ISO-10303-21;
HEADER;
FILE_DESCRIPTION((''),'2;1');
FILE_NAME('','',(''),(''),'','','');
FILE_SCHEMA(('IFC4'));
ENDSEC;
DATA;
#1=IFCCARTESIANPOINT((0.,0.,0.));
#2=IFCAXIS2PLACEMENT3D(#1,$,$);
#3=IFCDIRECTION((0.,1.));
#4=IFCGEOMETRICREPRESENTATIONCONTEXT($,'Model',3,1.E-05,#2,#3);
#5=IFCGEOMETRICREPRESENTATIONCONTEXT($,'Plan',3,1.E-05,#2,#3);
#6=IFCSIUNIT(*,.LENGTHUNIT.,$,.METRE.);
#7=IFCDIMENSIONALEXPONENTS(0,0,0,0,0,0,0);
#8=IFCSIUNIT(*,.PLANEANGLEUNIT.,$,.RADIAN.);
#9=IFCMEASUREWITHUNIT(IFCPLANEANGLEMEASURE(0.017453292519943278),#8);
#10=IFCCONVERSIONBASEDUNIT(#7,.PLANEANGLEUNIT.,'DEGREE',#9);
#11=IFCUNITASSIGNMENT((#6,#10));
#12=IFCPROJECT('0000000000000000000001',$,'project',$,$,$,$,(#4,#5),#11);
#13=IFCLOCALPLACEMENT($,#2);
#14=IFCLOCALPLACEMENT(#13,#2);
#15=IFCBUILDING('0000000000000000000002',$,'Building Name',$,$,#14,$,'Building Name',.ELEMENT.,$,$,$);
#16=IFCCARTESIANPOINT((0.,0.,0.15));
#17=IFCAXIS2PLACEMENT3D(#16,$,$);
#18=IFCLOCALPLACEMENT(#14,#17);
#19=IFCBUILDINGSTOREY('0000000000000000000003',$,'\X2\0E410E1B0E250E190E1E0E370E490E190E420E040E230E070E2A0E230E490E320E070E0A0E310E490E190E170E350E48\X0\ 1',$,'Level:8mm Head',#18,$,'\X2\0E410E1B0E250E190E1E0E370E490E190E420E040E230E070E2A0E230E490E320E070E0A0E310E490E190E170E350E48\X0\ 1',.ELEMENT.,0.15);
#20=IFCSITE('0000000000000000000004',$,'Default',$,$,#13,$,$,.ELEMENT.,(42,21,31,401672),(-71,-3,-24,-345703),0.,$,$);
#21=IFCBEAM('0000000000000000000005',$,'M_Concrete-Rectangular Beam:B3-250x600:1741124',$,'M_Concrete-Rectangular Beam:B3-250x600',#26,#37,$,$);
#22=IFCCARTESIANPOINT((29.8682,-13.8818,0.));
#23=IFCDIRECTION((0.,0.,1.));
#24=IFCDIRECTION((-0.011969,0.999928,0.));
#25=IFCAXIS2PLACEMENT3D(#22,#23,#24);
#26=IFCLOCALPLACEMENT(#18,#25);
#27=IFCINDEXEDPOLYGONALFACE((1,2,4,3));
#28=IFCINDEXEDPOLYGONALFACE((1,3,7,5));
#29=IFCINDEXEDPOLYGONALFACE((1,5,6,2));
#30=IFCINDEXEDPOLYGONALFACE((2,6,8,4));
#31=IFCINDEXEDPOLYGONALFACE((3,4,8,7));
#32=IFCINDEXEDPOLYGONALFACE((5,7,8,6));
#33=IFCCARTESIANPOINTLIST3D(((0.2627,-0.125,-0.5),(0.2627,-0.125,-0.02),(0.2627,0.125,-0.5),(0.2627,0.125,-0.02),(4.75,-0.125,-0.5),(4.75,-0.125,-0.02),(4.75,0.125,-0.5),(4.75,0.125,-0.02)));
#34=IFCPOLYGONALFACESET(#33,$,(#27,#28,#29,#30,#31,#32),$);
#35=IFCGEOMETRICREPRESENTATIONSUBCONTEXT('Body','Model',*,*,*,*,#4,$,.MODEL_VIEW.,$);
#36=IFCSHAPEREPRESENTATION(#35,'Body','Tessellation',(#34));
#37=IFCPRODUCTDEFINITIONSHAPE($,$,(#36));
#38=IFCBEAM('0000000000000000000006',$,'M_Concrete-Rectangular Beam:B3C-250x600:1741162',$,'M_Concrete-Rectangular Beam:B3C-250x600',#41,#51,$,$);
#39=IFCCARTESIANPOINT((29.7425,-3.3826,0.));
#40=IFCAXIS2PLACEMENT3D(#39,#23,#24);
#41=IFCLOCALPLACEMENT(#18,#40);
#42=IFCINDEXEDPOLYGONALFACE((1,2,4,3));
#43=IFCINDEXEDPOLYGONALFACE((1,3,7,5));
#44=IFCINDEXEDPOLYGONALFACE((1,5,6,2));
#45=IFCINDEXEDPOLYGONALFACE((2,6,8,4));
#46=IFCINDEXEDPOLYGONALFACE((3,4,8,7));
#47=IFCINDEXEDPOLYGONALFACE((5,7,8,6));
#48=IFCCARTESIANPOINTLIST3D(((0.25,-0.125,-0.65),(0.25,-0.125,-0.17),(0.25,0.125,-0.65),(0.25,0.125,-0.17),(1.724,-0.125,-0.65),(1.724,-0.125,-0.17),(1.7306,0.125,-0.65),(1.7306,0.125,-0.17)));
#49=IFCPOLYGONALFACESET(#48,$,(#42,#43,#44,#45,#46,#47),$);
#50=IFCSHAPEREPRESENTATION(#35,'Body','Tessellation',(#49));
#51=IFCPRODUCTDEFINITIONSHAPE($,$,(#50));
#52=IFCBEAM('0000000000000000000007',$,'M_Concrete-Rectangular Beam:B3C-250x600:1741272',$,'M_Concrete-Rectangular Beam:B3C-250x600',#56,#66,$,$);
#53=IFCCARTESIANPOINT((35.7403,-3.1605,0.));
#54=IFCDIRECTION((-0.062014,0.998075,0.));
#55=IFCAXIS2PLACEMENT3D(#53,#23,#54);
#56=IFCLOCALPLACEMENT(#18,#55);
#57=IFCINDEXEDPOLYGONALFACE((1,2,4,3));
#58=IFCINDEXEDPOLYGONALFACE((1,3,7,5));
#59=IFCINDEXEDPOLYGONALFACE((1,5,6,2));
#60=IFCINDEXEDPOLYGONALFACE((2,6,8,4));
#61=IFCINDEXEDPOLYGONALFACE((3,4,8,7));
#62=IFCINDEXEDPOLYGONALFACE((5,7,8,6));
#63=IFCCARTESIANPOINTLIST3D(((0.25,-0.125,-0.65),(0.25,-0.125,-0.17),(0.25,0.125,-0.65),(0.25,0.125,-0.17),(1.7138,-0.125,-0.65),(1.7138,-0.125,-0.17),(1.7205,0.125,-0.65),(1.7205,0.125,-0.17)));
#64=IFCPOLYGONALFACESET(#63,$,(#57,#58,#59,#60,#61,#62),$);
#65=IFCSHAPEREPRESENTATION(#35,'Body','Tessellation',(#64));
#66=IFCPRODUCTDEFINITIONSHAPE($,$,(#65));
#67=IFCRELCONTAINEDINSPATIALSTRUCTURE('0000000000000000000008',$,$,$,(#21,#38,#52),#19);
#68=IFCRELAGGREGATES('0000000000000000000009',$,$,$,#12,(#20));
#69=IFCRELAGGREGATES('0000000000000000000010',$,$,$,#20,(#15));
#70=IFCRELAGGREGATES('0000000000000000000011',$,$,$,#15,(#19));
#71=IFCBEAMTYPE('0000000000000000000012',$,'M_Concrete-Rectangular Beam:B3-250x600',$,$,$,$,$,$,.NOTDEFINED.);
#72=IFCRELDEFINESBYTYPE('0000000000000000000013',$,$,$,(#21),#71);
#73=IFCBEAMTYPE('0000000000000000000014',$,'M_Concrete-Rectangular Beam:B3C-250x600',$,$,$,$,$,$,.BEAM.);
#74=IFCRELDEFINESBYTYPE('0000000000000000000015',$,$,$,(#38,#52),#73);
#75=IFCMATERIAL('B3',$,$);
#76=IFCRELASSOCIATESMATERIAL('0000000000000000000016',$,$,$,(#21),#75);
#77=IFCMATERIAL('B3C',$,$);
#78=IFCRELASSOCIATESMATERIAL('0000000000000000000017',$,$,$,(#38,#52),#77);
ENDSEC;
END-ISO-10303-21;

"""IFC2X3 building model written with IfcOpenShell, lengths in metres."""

from ifc_helpers import new_model, entity, si_unit, converted_unit, direction, frame, frame_2d, origin, place, context, subcontext, project, spatial, rectangle, extrude, clip, halfspace, material, type_object, element, save


model = new_model("IFC2X3")

# Units and contexts
model_context = context("Model", 3, precision=1e-05, world=origin(), true_north=direction((0.0, 1.0)))
plan_context = context("Plan", 3, precision=1e-05, world=origin(), true_north=direction((0.0, 1.0)))
body_context = subcontext(model_context, "Body", "Model", "MODEL_VIEW")
ifc_project = project(units=[si_unit("LENGTHUNIT", "METRE"), converted_unit("PLANEANGLEUNIT", "DEGREE", entity("IfcPlaneAngleMeasure", 0.017453292519943278), si_unit("PLANEANGLEUNIT", "RADIAN"), dimensions=[0, 0, 0, 0, 0, 0, 0])], contexts=[model_context, plan_context])

# Site, building, storey
site_placement = place(None, origin())
site = spatial("IfcSite", under=ifc_project, at=site_placement, Name="Default", CompositionType="ELEMENT", RefLatitude=(42, 21, 31, 401672), RefLongitude=(-71, -3, -24, -345703), RefElevation=0.0)
building_placement = place(site_placement, origin())
building = spatial("IfcBuilding", under=site, at=building_placement, Name="Building Name", LongName="Building Name", CompositionType="ELEMENT")
storey_placement = place(building_placement, frame((0.0, 0.0, 0.15)))
storey = spatial("IfcBuildingStorey", under=building, at=storey_placement, Name="แปลนพื้นโครงสร้างชั้นที่ 1", ObjectType="Level:8mm Head", LongName="แปลนพื้นโครงสร้างชั้นที่ 1", CompositionType="ELEMENT", Elevation=0.15)

# Beams
ifc_material_1 = material(Name="B3")
beam_type_1 = type_object("IfcBeamType", Name="M_Concrete-Rectangular Beam:B3-250x600", PredefinedType="NOTDEFINED")
beam_1_placement = place(storey_placement, frame((29.8682, -13.8818, 0.0), z_axis=(0.0, 0.0, 1.0), x_axis=(-0.011969, 0.999928, 0.0)))
element("IfcBeam", 1, at=beam_1_placement, inside=storey, type_object=beam_type_1, material=ifc_material_1, Name="M_Concrete-Rectangular Beam:B3-250x600:1741124", ObjectType="M_Concrete-Rectangular Beam:B3-250x600", context=body_context, shape_type="SweptSolid", body=[
    extrude(rectangle(XDim=0.48, YDim=0.25, at=frame_2d((0.0, 0.0), x_axis=(1.0, 0.0))), frame((0.2627, 0.0, -0.26), z_axis=(1.0, 0.0, 0.0), x_axis=(0.0, 0.0, -1.0)), (0.0, 0.0, 1.0), 4.4873),
])
ifc_material_2 = material(Name="B3C")
beam_type_2 = type_object("IfcBeamType", Name="M_Concrete-Rectangular Beam:B3C-250x600", PredefinedType="BEAM")
beam_2_placement = place(storey_placement, frame((29.7425, -3.3826, 0.0), z_axis=(0.0, 0.0, 1.0), x_axis=(-0.011969, 0.999928, 0.0)))
element("IfcBeam", 2, at=beam_2_placement, inside=storey, type_object=beam_type_2, material=ifc_material_2, Name="M_Concrete-Rectangular Beam:B3C-250x600:1741162", ObjectType="M_Concrete-Rectangular Beam:B3C-250x600", context=body_context, shape_type="Clipping", body=[
    clip(extrude(rectangle(XDim=0.48, YDim=0.25, at=frame_2d((0.0, 0.0), x_axis=(1.0, 0.0))), frame((0.25, 0.0, -0.41), z_axis=(1.0, 0.0, 0.0), x_axis=(0.0, 0.0, -1.0)), (0.0, 0.0, 1.0), 1.4806), halfspace(frame((1.7312, 0.149, -0.05), z_axis=(0.99965, -0.026442, 0.0), x_axis=(-0.026442, -0.99965, 0.0)), False)),
])
beam_3_placement = place(storey_placement, frame((35.7403, -3.1605, 0.0), z_axis=(0.0, 0.0, 1.0), x_axis=(-0.062014, 0.998075, 0.0)))
element("IfcBeam", 3, at=beam_3_placement, inside=storey, type_object=beam_type_2, material=ifc_material_2, Name="M_Concrete-Rectangular Beam:B3C-250x600:1741272", ObjectType="M_Concrete-Rectangular Beam:B3C-250x600", context=body_context, shape_type="Clipping", body=[
    clip(extrude(rectangle(XDim=0.48, YDim=0.25, at=frame_2d((0.0, 0.0), x_axis=(1.0, 0.0))), frame((0.25, 0.0, -0.41), z_axis=(1.0, 0.0, 0.0), x_axis=(0.0, 0.0, -1.0)), (0.0, 0.0, 1.0), 1.4705), halfspace(frame((1.7212, 0.149, -0.05), z_axis=(0.999642, -0.026748, 0.0), x_axis=(-0.026748, -0.999642, 0.0)), False)),
])

save(model, "model.ifc")
